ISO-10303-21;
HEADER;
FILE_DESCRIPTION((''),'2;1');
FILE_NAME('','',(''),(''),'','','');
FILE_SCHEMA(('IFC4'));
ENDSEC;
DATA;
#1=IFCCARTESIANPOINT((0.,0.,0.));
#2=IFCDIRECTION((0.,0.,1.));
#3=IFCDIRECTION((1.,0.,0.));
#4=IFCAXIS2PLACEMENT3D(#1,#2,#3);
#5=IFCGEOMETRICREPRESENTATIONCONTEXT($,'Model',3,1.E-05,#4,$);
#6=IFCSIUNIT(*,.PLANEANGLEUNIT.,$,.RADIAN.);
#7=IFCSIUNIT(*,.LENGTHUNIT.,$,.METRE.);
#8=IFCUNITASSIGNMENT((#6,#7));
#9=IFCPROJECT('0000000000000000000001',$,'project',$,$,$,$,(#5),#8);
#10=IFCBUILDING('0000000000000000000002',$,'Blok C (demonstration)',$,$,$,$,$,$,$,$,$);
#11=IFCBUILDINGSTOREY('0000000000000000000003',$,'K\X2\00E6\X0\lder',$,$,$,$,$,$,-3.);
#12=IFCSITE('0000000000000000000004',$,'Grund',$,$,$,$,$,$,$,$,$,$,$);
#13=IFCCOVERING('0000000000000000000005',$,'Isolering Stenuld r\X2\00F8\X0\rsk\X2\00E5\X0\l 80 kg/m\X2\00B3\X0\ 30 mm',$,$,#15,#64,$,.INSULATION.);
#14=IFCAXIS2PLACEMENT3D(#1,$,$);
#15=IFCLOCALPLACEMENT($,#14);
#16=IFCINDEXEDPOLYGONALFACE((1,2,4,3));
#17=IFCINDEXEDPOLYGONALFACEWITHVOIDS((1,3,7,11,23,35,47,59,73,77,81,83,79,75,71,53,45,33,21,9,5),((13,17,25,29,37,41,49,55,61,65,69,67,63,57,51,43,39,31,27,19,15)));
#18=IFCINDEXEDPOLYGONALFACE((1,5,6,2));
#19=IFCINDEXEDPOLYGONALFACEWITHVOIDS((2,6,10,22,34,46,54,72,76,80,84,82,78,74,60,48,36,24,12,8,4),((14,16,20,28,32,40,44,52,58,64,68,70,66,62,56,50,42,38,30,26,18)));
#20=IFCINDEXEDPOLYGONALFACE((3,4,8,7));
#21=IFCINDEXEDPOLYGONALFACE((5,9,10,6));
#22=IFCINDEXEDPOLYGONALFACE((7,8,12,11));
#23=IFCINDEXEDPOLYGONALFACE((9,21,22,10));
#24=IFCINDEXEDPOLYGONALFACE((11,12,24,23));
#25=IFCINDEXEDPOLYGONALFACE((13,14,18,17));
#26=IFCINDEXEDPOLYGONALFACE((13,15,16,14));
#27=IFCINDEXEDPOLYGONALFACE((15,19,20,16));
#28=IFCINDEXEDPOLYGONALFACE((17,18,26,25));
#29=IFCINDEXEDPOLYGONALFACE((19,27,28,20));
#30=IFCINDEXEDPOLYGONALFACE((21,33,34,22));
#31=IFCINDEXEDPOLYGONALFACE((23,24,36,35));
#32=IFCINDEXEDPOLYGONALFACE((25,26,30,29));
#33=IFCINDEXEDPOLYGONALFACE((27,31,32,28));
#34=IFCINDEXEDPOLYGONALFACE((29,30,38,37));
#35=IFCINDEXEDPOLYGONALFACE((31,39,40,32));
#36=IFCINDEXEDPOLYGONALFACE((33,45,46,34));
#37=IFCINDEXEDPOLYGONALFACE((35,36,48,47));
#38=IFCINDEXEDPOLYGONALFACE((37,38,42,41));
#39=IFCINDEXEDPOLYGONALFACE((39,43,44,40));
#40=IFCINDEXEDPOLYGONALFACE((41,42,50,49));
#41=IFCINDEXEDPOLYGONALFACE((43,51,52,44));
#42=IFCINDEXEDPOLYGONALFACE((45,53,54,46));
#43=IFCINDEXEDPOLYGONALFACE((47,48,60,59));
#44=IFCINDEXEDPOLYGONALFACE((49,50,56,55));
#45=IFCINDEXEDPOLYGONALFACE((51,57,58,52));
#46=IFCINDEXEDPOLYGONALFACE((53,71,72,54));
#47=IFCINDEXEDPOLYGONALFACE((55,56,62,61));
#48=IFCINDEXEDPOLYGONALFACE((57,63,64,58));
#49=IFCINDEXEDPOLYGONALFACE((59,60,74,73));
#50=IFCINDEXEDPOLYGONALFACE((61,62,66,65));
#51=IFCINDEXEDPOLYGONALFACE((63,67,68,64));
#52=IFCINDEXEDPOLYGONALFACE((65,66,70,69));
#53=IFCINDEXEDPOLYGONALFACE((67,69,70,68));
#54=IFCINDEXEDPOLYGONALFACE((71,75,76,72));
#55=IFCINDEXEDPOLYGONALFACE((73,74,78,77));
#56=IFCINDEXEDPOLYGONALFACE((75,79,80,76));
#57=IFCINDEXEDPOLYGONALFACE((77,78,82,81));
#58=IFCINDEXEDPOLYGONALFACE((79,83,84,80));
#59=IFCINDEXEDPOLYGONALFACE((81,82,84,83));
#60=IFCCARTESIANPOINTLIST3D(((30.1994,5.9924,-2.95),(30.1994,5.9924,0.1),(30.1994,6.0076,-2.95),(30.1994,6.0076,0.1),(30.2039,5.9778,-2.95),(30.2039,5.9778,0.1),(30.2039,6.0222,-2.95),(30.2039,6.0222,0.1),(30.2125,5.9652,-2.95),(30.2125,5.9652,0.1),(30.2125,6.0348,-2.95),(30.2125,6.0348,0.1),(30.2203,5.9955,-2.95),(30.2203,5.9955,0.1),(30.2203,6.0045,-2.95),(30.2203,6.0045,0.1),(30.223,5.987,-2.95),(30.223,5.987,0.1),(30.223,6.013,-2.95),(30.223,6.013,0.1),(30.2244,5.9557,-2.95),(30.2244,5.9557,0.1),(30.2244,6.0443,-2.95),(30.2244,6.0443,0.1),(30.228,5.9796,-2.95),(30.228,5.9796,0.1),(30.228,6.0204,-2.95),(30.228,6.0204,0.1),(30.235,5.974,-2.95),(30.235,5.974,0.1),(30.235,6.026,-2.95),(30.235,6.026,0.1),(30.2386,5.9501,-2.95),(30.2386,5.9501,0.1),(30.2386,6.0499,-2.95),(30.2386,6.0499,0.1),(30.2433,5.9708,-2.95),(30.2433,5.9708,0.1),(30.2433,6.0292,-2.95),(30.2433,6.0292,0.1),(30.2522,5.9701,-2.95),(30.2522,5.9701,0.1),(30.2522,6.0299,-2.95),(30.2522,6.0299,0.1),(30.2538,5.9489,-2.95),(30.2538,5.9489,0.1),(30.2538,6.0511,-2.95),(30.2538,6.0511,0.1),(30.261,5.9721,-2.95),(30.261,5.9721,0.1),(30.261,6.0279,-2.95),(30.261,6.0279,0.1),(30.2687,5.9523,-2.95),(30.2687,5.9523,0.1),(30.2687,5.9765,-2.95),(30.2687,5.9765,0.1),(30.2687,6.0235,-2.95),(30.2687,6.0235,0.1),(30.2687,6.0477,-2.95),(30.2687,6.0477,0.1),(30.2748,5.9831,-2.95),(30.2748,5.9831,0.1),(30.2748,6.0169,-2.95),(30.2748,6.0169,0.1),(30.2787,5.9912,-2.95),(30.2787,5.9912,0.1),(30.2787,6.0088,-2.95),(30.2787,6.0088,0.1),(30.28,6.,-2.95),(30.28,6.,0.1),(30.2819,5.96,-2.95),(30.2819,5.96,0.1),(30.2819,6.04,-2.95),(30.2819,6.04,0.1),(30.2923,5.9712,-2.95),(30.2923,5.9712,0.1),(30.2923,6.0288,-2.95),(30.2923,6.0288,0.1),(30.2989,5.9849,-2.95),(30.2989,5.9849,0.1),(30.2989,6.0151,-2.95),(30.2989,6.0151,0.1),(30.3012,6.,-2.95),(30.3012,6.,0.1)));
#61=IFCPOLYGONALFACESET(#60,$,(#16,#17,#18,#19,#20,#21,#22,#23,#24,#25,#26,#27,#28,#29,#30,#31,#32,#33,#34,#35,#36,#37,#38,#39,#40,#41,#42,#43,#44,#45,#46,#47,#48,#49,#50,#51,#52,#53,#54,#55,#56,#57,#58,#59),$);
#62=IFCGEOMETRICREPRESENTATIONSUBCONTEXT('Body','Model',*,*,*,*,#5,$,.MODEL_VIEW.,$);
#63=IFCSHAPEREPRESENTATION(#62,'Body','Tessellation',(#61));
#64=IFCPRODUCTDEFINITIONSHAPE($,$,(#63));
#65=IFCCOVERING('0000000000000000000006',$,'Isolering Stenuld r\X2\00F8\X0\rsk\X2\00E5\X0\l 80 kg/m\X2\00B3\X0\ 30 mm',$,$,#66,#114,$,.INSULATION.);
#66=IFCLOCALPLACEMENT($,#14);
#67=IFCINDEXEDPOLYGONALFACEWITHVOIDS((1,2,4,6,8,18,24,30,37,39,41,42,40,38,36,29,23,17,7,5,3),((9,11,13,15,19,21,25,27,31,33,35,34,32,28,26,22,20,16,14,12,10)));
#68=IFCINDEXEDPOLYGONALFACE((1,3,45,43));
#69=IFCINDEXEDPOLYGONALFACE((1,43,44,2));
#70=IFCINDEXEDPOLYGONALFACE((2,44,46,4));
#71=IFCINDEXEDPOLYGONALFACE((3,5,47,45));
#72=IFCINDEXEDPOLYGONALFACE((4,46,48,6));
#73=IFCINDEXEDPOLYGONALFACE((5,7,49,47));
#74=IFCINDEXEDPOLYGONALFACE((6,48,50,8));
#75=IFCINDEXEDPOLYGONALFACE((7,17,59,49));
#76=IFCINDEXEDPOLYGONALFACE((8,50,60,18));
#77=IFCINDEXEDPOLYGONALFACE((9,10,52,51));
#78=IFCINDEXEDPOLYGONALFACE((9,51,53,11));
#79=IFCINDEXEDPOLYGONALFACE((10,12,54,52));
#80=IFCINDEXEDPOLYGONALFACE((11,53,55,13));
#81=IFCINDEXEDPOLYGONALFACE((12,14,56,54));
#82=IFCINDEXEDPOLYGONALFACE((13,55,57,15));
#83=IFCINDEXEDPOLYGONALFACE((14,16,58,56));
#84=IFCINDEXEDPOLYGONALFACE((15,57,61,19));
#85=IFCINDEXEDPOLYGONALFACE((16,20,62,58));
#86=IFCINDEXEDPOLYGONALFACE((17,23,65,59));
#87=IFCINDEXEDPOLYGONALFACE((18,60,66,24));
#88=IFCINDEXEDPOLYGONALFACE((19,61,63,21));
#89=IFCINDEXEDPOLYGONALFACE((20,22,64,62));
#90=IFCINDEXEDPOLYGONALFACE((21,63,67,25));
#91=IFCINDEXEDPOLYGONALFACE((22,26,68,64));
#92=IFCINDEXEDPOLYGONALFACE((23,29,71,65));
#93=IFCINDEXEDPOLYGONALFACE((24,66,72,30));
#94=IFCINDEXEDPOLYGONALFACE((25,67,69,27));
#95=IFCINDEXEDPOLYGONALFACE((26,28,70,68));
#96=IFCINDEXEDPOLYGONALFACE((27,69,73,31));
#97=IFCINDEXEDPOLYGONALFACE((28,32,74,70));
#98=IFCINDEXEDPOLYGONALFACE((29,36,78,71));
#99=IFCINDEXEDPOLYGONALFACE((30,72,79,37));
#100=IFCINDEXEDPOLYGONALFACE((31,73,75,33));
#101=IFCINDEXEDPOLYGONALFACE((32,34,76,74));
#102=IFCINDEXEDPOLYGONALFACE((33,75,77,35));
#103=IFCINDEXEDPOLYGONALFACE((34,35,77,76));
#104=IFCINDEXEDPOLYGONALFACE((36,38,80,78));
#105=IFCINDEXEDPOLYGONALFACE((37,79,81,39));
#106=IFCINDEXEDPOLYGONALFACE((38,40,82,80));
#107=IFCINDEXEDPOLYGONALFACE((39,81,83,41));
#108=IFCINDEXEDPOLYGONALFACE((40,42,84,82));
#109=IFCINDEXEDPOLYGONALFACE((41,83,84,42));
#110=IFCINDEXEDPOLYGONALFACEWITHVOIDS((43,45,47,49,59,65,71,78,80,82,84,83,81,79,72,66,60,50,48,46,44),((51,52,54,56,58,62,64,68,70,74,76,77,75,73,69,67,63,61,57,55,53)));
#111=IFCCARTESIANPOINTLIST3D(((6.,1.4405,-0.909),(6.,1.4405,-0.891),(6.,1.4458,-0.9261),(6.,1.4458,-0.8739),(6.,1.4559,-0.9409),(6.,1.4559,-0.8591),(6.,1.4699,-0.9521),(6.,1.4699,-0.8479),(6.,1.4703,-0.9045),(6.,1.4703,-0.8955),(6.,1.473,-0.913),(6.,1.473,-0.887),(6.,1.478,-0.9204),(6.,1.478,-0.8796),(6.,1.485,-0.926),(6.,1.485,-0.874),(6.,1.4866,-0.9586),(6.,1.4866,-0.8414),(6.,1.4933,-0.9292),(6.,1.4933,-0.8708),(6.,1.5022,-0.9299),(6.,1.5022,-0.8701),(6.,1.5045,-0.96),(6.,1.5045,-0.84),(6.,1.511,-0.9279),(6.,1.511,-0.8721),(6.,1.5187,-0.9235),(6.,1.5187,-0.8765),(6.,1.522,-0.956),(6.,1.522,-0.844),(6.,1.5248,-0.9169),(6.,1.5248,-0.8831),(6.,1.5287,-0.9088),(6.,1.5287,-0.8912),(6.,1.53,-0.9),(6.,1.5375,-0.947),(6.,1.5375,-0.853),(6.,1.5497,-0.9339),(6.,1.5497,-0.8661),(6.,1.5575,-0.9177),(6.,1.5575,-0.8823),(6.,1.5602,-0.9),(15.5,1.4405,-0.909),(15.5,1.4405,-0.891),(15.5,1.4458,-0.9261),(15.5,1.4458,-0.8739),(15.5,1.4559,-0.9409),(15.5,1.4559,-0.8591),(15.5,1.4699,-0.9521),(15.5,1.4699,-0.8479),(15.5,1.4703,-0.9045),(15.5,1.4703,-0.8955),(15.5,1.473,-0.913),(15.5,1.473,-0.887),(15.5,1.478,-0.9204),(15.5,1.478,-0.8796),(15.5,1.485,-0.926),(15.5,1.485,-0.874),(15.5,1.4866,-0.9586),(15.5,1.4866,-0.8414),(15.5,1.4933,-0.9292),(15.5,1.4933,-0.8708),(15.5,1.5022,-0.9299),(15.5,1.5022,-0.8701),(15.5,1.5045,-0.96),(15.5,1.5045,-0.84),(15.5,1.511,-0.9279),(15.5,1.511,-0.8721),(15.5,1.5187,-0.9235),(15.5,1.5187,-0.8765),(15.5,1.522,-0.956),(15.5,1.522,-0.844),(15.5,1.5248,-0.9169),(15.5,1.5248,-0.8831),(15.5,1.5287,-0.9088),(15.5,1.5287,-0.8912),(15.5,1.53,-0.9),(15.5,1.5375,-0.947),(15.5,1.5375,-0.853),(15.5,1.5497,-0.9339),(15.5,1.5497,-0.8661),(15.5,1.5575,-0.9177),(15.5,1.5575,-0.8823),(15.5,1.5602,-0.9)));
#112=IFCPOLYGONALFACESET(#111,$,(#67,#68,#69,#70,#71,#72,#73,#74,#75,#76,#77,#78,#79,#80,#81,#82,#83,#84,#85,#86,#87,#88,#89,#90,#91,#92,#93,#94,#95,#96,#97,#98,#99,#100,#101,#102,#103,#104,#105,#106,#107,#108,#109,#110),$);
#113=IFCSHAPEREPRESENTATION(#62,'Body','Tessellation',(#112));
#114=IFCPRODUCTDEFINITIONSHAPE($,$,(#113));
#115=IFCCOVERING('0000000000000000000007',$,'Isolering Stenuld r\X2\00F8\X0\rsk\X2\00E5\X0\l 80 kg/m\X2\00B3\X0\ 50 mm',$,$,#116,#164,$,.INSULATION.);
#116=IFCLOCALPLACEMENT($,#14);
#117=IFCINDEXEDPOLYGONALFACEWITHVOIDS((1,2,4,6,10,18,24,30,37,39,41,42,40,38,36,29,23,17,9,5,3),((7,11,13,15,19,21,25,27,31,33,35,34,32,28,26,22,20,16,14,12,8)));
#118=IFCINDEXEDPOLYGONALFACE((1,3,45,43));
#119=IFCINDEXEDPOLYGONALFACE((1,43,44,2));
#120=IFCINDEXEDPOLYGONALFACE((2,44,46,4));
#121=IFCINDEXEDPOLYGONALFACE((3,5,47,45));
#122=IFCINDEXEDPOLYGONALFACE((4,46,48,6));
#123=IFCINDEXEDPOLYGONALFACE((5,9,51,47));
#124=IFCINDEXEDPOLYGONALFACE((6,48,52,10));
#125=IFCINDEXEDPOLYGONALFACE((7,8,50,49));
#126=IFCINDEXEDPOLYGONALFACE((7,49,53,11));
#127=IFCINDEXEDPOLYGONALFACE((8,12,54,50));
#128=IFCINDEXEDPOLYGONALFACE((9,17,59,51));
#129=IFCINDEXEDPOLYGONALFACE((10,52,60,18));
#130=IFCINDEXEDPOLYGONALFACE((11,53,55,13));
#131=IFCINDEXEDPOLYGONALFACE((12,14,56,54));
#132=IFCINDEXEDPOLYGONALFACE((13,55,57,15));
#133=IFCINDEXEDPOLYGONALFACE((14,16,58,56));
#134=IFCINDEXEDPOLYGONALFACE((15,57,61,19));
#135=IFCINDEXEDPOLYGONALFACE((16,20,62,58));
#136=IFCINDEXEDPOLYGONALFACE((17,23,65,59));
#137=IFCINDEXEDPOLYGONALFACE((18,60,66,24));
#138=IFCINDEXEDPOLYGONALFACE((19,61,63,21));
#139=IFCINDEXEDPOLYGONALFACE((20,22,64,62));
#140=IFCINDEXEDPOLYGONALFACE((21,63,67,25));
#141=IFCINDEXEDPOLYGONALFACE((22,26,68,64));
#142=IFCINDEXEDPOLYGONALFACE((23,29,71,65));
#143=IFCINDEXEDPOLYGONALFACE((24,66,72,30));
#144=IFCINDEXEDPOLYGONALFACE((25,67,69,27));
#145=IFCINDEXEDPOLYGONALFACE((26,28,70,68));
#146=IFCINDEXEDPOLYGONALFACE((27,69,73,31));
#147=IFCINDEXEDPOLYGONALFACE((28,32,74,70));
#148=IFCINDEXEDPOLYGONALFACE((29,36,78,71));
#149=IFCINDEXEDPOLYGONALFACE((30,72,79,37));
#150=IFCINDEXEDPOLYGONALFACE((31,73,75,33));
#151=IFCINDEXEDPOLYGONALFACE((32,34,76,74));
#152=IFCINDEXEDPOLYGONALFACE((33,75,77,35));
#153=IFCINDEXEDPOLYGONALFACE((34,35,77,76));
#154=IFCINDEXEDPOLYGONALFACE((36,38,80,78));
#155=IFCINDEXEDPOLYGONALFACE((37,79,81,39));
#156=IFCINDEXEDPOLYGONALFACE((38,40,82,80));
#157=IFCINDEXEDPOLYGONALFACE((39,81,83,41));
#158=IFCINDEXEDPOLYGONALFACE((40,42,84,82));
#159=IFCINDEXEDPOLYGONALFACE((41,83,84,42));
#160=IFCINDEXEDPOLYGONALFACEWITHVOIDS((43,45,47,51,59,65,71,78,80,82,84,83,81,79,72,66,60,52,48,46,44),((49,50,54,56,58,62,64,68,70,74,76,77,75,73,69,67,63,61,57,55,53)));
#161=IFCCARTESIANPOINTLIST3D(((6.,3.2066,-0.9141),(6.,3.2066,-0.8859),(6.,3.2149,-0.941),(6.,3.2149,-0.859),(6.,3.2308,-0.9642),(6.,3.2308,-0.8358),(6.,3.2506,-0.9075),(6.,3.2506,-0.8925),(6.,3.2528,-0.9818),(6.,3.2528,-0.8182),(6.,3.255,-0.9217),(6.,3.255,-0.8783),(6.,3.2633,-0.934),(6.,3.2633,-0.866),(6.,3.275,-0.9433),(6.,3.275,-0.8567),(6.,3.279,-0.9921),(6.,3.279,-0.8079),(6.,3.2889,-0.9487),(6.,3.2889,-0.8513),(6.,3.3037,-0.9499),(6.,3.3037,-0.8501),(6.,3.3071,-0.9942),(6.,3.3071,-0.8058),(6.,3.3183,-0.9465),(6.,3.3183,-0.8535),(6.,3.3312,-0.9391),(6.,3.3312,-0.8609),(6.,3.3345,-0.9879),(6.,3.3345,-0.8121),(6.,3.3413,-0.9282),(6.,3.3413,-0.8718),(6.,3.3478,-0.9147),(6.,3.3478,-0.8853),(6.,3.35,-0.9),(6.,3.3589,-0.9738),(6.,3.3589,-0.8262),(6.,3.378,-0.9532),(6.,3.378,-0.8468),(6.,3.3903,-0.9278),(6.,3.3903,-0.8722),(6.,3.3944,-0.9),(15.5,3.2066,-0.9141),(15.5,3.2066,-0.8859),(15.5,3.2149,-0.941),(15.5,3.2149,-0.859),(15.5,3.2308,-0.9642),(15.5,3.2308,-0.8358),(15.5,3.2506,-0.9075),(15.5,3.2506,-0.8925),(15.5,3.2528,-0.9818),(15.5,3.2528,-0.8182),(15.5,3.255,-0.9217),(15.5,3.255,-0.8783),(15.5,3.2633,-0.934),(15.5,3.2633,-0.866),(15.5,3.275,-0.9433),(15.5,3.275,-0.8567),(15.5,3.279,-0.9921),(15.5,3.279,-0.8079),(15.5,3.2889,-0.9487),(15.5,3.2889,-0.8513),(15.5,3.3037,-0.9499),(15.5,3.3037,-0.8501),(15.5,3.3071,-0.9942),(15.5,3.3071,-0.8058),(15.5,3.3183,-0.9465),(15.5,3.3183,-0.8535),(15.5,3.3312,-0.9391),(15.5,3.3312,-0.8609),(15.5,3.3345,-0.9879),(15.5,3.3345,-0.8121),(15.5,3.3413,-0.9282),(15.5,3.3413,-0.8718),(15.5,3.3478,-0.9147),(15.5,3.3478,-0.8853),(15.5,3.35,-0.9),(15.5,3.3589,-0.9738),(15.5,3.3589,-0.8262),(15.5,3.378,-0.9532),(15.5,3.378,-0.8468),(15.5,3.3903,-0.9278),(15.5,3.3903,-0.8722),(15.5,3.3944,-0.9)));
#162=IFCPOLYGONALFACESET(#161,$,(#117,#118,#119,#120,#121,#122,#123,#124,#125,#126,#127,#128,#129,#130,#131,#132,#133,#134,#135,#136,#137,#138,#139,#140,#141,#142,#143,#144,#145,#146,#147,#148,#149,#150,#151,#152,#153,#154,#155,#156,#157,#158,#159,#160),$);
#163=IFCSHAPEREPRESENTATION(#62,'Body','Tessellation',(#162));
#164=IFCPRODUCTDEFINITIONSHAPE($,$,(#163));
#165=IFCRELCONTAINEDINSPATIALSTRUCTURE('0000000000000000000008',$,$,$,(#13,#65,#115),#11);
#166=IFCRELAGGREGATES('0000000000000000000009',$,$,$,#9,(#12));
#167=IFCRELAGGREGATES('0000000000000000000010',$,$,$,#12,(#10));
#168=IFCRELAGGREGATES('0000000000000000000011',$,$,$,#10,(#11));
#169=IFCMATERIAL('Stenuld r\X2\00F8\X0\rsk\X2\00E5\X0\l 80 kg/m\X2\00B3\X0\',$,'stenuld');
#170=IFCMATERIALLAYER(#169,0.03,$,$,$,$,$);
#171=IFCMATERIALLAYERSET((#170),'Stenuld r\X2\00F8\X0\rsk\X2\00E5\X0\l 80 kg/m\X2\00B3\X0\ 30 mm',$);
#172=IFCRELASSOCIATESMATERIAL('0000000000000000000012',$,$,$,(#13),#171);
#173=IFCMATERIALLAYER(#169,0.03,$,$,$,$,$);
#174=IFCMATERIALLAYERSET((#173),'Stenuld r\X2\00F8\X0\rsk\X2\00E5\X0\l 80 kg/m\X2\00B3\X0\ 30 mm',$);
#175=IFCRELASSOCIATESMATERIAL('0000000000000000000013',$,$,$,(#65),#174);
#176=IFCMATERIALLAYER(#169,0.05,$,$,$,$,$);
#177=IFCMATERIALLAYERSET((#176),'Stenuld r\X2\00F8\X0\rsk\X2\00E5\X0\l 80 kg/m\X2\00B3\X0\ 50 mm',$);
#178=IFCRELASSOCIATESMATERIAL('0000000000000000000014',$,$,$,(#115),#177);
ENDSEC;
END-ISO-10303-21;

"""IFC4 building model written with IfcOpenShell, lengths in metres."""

from ifc_helpers import new_model, si_unit, frame, origin_with_axes, place, context, subcontext, project, spatial, hollow_circle, extrude, material, layer, layer_set, element, save


model = new_model("IFC4")

# Units and contexts
model_context = context("Model", 3, precision=1e-05, world=origin_with_axes())
body_context = subcontext(model_context, "Body", "Model", "MODEL_VIEW")
ifc_project = project(units=[si_unit("PLANEANGLEUNIT", "RADIAN"), si_unit("LENGTHUNIT", "METRE")], contexts=[model_context])

# Site, building, storey
site = spatial("IfcSite", under=ifc_project, Name="Grund")
building = spatial("IfcBuilding", under=site, Name="Blok C (demonstration)")
storey = spatial("IfcBuildingStorey", under=building, Name="Kælder", Elevation=-3.0)

# Coverings
ifc_material_1 = material(Name="Stenuld rørskål 80 kg/m³", Category="stenuld")
ifc_layer_1 = layer(ifc_material_1, 0.03)
ifc_layer_set_1 = layer_set([ifc_layer_1], Name="Stenuld rørskål 80 kg/m³ 30 mm")
covering_1_placement = place(None, origin_with_axes())
element("IfcCovering", 1, at=covering_1_placement, inside=storey, material=ifc_layer_set_1, Name="Isolering Stenuld rørskål 80 kg/m³ 30 mm", PredefinedType="INSULATION", context=body_context, shape_type="SweptSolid", body=[
    extrude(hollow_circle(Radius=0.0512, WallThickness=0.0212), frame((30.25, 6.0, -2.95), z_axis=(0.0, 0.0, 1.0), x_axis=(1.0, 0.0, 0.0)), (0.0, 0.0, 1.0), 3.05),
])
ifc_layer_2 = layer(ifc_material_1, 0.03)
ifc_layer_set_2 = layer_set([ifc_layer_2], Name="Stenuld rørskål 80 kg/m³ 30 mm")
covering_2_placement = place(None, origin_with_axes())
element("IfcCovering", 2, at=covering_2_placement, inside=storey, material=ifc_layer_set_2, Name="Isolering Stenuld rørskål 80 kg/m³ 30 mm", PredefinedType="INSULATION", context=body_context, shape_type="SweptSolid", body=[
    extrude(hollow_circle(Radius=0.0601, WallThickness=0.0301), frame((6.0, 1.5, -0.9), z_axis=(1.0, 0.0, 0.0), x_axis=(0.0, 1.0, 0.0)), (0.0, 0.0, 1.0), 9.5),
])
ifc_layer_3 = layer(ifc_material_1, 0.05)
ifc_layer_set_3 = layer_set([ifc_layer_3], Name="Stenuld rørskål 80 kg/m³ 50 mm")
covering_3_placement = place(None, origin_with_axes())
element("IfcCovering", 3, at=covering_3_placement, inside=storey, material=ifc_layer_set_3, Name="Isolering Stenuld rørskål 80 kg/m³ 50 mm", PredefinedType="INSULATION", context=body_context, shape_type="SweptSolid", body=[
    extrude(hollow_circle(Radius=0.0945, WallThickness=0.0445), frame((6.0, 3.3, -0.9), z_axis=(1.0, 0.0, 0.0), x_axis=(0.0, 1.0, 0.0)), (0.0, 0.0, 1.0), 9.5),
])

save(model, "model.ifc")
